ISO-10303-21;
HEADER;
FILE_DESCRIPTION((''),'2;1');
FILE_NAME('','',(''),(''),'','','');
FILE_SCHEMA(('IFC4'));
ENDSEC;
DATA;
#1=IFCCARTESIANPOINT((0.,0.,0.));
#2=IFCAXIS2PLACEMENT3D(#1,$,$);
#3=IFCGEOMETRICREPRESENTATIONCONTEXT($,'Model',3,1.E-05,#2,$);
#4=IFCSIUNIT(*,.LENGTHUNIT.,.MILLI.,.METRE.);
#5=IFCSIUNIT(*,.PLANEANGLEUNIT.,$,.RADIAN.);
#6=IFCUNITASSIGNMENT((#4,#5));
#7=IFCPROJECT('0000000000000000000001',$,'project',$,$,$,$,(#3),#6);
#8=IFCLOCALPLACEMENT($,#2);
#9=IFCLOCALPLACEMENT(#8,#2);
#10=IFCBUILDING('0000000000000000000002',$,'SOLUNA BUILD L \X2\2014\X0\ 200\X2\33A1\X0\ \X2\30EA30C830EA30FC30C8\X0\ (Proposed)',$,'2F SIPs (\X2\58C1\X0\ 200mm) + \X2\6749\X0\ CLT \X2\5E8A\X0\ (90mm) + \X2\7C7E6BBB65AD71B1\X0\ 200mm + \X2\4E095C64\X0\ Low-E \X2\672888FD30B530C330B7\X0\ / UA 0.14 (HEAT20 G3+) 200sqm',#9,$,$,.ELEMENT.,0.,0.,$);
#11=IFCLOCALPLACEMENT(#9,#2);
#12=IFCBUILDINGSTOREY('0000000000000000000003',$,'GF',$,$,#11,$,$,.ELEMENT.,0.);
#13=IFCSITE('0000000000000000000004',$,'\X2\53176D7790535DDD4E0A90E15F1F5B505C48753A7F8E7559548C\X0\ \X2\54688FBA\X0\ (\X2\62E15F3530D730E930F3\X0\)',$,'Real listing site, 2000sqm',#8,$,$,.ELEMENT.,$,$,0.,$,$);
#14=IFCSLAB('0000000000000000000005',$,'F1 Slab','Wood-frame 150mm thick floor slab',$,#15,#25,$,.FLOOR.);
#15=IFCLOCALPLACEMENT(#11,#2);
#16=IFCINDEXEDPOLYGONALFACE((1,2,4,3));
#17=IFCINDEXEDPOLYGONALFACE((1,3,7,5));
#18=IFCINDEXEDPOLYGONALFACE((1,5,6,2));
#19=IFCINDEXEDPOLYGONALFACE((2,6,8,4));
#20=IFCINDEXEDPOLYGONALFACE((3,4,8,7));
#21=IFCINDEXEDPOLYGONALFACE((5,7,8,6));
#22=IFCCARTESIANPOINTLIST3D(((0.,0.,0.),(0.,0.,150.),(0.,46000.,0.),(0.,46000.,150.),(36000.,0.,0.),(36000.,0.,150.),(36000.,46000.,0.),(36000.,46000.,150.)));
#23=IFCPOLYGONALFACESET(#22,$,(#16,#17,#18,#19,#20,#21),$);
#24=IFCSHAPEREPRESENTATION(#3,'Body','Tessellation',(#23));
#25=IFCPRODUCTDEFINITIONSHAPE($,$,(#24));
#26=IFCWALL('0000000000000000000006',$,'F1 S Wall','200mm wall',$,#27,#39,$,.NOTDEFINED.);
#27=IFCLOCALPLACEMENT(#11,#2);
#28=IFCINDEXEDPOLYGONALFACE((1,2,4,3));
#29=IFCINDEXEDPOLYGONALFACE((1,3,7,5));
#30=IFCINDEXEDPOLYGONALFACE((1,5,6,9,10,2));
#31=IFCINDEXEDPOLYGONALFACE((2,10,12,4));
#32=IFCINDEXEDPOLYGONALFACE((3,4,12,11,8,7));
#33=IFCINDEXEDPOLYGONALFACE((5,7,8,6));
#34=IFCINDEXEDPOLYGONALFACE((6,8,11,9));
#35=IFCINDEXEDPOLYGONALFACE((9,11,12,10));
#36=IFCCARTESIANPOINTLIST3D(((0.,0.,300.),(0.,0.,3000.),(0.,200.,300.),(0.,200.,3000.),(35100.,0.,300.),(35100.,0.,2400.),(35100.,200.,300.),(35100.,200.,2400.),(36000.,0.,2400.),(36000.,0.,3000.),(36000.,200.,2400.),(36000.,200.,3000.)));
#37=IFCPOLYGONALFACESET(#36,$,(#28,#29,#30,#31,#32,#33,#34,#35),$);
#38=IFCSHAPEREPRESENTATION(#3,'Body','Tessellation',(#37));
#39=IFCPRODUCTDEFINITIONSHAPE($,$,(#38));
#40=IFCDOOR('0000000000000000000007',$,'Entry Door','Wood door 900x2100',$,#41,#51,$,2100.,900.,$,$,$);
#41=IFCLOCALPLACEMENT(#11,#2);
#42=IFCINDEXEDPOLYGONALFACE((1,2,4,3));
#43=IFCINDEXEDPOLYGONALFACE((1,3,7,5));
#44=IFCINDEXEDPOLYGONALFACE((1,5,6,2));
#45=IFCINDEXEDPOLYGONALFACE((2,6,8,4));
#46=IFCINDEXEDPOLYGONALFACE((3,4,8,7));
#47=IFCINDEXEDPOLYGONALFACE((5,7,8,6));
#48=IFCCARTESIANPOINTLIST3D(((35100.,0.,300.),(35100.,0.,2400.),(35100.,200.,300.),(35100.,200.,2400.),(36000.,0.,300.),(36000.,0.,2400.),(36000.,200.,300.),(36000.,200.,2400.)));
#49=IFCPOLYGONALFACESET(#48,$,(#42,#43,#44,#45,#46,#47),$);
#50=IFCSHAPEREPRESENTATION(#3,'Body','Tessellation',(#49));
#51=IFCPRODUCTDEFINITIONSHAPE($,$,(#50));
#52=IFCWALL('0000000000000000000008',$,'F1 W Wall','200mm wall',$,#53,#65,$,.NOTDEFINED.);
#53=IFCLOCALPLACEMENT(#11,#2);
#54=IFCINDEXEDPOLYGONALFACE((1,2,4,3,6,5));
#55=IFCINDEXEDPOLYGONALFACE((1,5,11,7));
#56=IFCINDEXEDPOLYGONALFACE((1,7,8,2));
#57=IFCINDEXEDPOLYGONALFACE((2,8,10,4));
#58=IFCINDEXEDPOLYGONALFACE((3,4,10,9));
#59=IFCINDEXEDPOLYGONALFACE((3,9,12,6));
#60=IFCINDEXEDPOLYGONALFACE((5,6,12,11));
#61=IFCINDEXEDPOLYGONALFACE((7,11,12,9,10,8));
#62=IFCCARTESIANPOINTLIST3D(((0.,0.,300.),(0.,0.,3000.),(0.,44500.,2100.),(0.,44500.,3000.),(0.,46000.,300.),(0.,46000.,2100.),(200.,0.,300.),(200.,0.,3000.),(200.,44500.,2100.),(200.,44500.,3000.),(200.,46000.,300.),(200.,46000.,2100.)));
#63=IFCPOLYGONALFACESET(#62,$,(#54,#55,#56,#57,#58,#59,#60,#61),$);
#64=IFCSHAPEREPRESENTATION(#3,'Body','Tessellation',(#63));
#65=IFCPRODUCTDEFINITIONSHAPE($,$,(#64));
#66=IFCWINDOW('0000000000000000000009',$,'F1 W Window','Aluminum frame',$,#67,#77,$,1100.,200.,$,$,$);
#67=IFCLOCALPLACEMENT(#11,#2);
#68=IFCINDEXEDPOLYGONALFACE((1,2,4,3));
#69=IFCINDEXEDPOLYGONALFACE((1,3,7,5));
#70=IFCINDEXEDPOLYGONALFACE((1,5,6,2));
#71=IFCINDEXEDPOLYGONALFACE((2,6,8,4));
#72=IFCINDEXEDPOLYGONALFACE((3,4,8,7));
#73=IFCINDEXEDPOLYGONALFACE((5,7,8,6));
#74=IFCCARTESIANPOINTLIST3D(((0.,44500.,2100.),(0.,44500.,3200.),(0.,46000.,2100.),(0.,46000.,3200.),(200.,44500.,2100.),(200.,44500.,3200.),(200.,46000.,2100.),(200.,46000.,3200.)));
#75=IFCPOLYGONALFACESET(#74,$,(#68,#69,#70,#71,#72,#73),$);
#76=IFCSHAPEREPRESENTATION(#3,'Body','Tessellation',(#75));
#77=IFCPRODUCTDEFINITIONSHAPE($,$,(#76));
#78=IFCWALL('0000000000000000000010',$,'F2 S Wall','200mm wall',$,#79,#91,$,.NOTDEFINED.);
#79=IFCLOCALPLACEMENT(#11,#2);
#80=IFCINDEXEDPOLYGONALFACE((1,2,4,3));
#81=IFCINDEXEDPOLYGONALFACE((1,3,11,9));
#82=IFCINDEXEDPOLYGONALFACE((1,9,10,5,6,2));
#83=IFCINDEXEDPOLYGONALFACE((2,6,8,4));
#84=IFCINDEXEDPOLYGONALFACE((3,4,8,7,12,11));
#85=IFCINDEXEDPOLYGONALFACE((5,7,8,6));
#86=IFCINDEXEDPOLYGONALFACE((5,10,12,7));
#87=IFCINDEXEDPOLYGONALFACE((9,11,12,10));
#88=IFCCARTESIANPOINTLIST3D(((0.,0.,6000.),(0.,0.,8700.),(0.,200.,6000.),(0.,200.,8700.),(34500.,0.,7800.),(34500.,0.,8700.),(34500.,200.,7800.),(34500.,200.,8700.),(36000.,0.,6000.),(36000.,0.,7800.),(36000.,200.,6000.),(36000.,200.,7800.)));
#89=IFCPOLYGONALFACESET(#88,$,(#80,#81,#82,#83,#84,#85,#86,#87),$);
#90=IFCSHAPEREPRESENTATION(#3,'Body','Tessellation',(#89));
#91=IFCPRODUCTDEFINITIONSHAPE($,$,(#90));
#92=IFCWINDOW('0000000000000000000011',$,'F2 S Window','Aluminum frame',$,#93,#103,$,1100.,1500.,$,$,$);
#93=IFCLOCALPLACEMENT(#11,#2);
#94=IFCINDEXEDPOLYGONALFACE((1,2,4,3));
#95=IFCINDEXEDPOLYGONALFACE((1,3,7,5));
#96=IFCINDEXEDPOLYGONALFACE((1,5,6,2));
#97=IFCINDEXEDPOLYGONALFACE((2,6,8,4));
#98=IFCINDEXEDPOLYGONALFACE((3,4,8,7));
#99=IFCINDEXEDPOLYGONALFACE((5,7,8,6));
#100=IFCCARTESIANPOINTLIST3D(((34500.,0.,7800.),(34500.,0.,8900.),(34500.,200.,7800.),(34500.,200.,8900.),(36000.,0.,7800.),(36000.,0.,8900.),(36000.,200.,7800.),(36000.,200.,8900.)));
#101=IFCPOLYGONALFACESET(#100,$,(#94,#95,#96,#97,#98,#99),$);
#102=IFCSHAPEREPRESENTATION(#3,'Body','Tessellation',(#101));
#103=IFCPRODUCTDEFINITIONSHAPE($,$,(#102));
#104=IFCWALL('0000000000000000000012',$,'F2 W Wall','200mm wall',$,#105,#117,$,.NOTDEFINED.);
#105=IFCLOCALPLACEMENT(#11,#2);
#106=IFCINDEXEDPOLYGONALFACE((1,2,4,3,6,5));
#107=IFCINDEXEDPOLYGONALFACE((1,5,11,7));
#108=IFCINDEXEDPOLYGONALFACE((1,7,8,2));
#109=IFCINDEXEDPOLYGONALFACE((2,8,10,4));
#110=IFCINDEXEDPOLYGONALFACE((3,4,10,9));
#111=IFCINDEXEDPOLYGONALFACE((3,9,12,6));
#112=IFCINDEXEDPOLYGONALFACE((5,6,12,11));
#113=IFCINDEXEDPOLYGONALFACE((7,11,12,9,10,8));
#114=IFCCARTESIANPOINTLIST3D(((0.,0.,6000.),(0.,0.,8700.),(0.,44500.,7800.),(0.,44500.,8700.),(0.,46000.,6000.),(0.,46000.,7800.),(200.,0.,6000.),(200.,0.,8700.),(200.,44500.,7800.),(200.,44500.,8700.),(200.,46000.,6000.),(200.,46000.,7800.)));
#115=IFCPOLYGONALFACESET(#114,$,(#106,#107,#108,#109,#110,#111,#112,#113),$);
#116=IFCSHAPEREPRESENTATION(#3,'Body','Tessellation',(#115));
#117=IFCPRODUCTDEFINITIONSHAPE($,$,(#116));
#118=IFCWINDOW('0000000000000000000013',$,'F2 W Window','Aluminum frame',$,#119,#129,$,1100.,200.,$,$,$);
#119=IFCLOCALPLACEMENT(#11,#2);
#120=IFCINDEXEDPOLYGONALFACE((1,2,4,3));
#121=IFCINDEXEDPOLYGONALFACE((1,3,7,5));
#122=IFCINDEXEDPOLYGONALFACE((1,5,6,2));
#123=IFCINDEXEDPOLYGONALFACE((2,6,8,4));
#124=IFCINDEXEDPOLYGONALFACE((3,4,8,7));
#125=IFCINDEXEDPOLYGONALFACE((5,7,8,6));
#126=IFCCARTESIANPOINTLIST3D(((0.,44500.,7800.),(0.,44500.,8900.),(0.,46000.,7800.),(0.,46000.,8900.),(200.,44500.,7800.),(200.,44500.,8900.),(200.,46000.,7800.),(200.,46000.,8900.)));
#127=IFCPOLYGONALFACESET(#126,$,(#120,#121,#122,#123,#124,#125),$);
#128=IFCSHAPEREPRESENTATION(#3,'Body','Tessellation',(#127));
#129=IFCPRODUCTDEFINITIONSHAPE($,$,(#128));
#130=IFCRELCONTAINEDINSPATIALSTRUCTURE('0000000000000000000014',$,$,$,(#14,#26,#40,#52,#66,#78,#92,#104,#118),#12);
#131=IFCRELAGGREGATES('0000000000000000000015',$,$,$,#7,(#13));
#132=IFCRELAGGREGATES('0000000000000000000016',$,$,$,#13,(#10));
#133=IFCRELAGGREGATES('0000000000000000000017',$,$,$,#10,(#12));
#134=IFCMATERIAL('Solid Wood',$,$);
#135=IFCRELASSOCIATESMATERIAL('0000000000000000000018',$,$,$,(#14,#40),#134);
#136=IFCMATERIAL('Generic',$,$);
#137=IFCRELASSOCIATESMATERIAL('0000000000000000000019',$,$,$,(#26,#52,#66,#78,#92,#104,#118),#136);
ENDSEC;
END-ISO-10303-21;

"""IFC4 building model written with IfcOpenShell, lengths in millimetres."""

from ifc_helpers import new_model, si_unit, frame, frame_2d, origin, place, context, project, spatial, rectangle, extrude, material, element, fill, save


model = new_model("IFC4")

# Units and contexts
model_context = context("Model", 3, precision=1e-05, world=origin())
ifc_project = project(units=[si_unit("LENGTHUNIT", "METRE", prefix="MILLI"), si_unit("PLANEANGLEUNIT", "RADIAN")], contexts=[model_context])

# Site, building, storey
site_placement = place(None, origin())
site = spatial("IfcSite", under=ifc_project, at=site_placement, Name="北海道川上郡弟子屈町美留和 周辺 (拡張プラン)", ObjectType="Real listing site, 2000sqm", CompositionType="ELEMENT", RefElevation=0.0)
building_placement = place(site_placement, origin())
building = spatial("IfcBuilding", under=site, at=building_placement, Name="SOLUNA BUILD L — 200㎡ リトリート (Proposed)", ObjectType="2F SIPs (壁 200mm) + 杉 CLT 床 (90mm) + 籾殻断熱 200mm + 三層 Low-E 木製サッシ / UA 0.14 (HEAT20 G3+) 200sqm", CompositionType="ELEMENT", ElevationOfRefHeight=0.0, ElevationOfTerrain=0.0)
storey_placement = place(building_placement, origin())
storey = spatial("IfcBuildingStorey", under=building, at=storey_placement, Name="GF", CompositionType="ELEMENT", Elevation=0.0)

# Slab
ifc_material_1 = material(Name="Solid Wood")
slab_1_placement = place(storey_placement, origin())
element("IfcSlab", 1, at=slab_1_placement, inside=storey, material=ifc_material_1, Name="F1 Slab", Description="Wood-frame 150mm thick floor slab", PredefinedType="FLOOR", context=model_context, shape_type="SweptSolid", body=[
    extrude(rectangle(XDim=36000.0, YDim=46000.0, at=frame_2d((18000.0, 23000.0))), origin(), (0.0, 0.0, 1.0), 150.0),
])

# Shared definitions
ifc_material_2 = material(Name="Generic")

# Wall, opening, door
wall_1_placement = place(storey_placement, frame((0.0, 0.0, 150.0)))
wall_1 = element("IfcWall", 2, at=wall_1_placement, inside=storey, material=ifc_material_2, Name="F1 S Wall", Description="200mm wall", PredefinedType="NOTDEFINED", context=model_context, shape_type="SweptSolid", body=[
    extrude(rectangle(XDim=36000.0, YDim=200.0, at=frame_2d((18000.0, 100.0))), frame((0.0, 0.0, 150.0)), (0.0, 0.0, 1.0), 2700.0),
])
opening_1_placement = place(storey_placement, frame((17550.0, 0.0, 150.0)))
opening_1 = element("IfcOpeningElement", 3, at=opening_1_placement, cuts=wall_1, PredefinedType="NOTDEFINED", context=model_context, shape_type="SweptSolid", body=[
    extrude(rectangle(XDim=900.0, YDim=200.0, at=frame_2d((450.0, 100.0))), frame((17550.0, 0.0, 150.0)), (0.0, 0.0, 1.0), 2100.0),
])
door_placement = place(storey_placement, frame((17550.0, 0.0, 150.0)))
door = element("IfcDoor", 4, at=door_placement, inside=storey, material=ifc_material_1, Name="Entry Door", Description="Wood door 900x2100", OverallHeight=2100.0, OverallWidth=900.0, context=model_context, shape_type="SweptSolid", body=[
    extrude(rectangle(XDim=900.0, YDim=200.0, at=frame_2d((450.0, 100.0))), frame((17550.0, 0.0, 150.0)), (0.0, 0.0, 1.0), 2100.0),
])
fill(opening_1, door)

# Walls, openings, windows
wall_2_placement = place(storey_placement, frame((0.0, 0.0, 150.0)))
wall_2 = element("IfcWall", 5, at=wall_2_placement, inside=storey, material=ifc_material_2, Name="F1 W Wall", Description="200mm wall", PredefinedType="NOTDEFINED", context=model_context, shape_type="SweptSolid", body=[
    extrude(rectangle(XDim=200.0, YDim=46000.0, at=frame_2d((100.0, 23000.0))), frame((0.0, 0.0, 150.0)), (0.0, 0.0, 1.0), 2700.0),
])
opening_2_placement = place(storey_placement, frame((0.0, 22250.0, 1050.0)))
opening_2 = element("IfcOpeningElement", 6, at=opening_2_placement, cuts=wall_2, PredefinedType="NOTDEFINED", context=model_context, shape_type="SweptSolid", body=[
    extrude(rectangle(XDim=200.0, YDim=1500.0, at=frame_2d((100.0, 750.0))), frame((0.0, 22250.0, 1050.0)), (0.0, 0.0, 1.0), 1100.0),
])
window_1_placement = place(storey_placement, frame((0.0, 22250.0, 1050.0)))
window_1 = element("IfcWindow", 7, at=window_1_placement, inside=storey, material=ifc_material_2, Name="F1 W Window", Description="Aluminum frame", OverallHeight=1100.0, OverallWidth=200.0, context=model_context, shape_type="SweptSolid", body=[
    extrude(rectangle(XDim=200.0, YDim=1500.0, at=frame_2d((100.0, 750.0))), frame((0.0, 22250.0, 1050.0)), (0.0, 0.0, 1.0), 1100.0),
])
fill(opening_2, window_1)
wall_3_placement = place(storey_placement, frame((0.0, 0.0, 3000.0)))
wall_3 = element("IfcWall", 8, at=wall_3_placement, inside=storey, material=ifc_material_2, Name="F2 S Wall", Description="200mm wall", PredefinedType="NOTDEFINED", context=model_context, shape_type="SweptSolid", body=[
    extrude(rectangle(XDim=36000.0, YDim=200.0, at=frame_2d((18000.0, 100.0))), frame((0.0, 0.0, 3000.0)), (0.0, 0.0, 1.0), 2700.0),
])
opening_3_placement = place(storey_placement, frame((17250.0, 0.0, 3900.0)))
opening_3 = element("IfcOpeningElement", 9, at=opening_3_placement, cuts=wall_3, PredefinedType="NOTDEFINED", context=model_context, shape_type="SweptSolid", body=[
    extrude(rectangle(XDim=1500.0, YDim=200.0, at=frame_2d((750.0, 100.0))), frame((17250.0, 0.0, 3900.0)), (0.0, 0.0, 1.0), 1100.0),
])
window_2_placement = place(storey_placement, frame((17250.0, 0.0, 3900.0)))
window_2 = element("IfcWindow", 10, at=window_2_placement, inside=storey, material=ifc_material_2, Name="F2 S Window", Description="Aluminum frame", OverallHeight=1100.0, OverallWidth=1500.0, context=model_context, shape_type="SweptSolid", body=[
    extrude(rectangle(XDim=1500.0, YDim=200.0, at=frame_2d((750.0, 100.0))), frame((17250.0, 0.0, 3900.0)), (0.0, 0.0, 1.0), 1100.0),
])
fill(opening_3, window_2)
wall_4_placement = place(storey_placement, frame((0.0, 0.0, 3000.0)))
wall_4 = element("IfcWall", 11, at=wall_4_placement, inside=storey, material=ifc_material_2, Name="F2 W Wall", Description="200mm wall", PredefinedType="NOTDEFINED", context=model_context, shape_type="SweptSolid", body=[
    extrude(rectangle(XDim=200.0, YDim=46000.0, at=frame_2d((100.0, 23000.0))), frame((0.0, 0.0, 3000.0)), (0.0, 0.0, 1.0), 2700.0),
])
opening_4_placement = place(storey_placement, frame((0.0, 22250.0, 3900.0)))
opening_4 = element("IfcOpeningElement", 12, at=opening_4_placement, cuts=wall_4, PredefinedType="NOTDEFINED", context=model_context, shape_type="SweptSolid", body=[
    extrude(rectangle(XDim=200.0, YDim=1500.0, at=frame_2d((100.0, 750.0))), frame((0.0, 22250.0, 3900.0)), (0.0, 0.0, 1.0), 1100.0),
])
window_3_placement = place(storey_placement, frame((0.0, 22250.0, 3900.0)))
window_3 = element("IfcWindow", 13, at=window_3_placement, inside=storey, material=ifc_material_2, Name="F2 W Window", Description="Aluminum frame", OverallHeight=1100.0, OverallWidth=200.0, context=model_context, shape_type="SweptSolid", body=[
    extrude(rectangle(XDim=200.0, YDim=1500.0, at=frame_2d((100.0, 750.0))), frame((0.0, 22250.0, 3900.0)), (0.0, 0.0, 1.0), 1100.0),
])
fill(opening_4, window_3)

save(model, "model.ifc")
